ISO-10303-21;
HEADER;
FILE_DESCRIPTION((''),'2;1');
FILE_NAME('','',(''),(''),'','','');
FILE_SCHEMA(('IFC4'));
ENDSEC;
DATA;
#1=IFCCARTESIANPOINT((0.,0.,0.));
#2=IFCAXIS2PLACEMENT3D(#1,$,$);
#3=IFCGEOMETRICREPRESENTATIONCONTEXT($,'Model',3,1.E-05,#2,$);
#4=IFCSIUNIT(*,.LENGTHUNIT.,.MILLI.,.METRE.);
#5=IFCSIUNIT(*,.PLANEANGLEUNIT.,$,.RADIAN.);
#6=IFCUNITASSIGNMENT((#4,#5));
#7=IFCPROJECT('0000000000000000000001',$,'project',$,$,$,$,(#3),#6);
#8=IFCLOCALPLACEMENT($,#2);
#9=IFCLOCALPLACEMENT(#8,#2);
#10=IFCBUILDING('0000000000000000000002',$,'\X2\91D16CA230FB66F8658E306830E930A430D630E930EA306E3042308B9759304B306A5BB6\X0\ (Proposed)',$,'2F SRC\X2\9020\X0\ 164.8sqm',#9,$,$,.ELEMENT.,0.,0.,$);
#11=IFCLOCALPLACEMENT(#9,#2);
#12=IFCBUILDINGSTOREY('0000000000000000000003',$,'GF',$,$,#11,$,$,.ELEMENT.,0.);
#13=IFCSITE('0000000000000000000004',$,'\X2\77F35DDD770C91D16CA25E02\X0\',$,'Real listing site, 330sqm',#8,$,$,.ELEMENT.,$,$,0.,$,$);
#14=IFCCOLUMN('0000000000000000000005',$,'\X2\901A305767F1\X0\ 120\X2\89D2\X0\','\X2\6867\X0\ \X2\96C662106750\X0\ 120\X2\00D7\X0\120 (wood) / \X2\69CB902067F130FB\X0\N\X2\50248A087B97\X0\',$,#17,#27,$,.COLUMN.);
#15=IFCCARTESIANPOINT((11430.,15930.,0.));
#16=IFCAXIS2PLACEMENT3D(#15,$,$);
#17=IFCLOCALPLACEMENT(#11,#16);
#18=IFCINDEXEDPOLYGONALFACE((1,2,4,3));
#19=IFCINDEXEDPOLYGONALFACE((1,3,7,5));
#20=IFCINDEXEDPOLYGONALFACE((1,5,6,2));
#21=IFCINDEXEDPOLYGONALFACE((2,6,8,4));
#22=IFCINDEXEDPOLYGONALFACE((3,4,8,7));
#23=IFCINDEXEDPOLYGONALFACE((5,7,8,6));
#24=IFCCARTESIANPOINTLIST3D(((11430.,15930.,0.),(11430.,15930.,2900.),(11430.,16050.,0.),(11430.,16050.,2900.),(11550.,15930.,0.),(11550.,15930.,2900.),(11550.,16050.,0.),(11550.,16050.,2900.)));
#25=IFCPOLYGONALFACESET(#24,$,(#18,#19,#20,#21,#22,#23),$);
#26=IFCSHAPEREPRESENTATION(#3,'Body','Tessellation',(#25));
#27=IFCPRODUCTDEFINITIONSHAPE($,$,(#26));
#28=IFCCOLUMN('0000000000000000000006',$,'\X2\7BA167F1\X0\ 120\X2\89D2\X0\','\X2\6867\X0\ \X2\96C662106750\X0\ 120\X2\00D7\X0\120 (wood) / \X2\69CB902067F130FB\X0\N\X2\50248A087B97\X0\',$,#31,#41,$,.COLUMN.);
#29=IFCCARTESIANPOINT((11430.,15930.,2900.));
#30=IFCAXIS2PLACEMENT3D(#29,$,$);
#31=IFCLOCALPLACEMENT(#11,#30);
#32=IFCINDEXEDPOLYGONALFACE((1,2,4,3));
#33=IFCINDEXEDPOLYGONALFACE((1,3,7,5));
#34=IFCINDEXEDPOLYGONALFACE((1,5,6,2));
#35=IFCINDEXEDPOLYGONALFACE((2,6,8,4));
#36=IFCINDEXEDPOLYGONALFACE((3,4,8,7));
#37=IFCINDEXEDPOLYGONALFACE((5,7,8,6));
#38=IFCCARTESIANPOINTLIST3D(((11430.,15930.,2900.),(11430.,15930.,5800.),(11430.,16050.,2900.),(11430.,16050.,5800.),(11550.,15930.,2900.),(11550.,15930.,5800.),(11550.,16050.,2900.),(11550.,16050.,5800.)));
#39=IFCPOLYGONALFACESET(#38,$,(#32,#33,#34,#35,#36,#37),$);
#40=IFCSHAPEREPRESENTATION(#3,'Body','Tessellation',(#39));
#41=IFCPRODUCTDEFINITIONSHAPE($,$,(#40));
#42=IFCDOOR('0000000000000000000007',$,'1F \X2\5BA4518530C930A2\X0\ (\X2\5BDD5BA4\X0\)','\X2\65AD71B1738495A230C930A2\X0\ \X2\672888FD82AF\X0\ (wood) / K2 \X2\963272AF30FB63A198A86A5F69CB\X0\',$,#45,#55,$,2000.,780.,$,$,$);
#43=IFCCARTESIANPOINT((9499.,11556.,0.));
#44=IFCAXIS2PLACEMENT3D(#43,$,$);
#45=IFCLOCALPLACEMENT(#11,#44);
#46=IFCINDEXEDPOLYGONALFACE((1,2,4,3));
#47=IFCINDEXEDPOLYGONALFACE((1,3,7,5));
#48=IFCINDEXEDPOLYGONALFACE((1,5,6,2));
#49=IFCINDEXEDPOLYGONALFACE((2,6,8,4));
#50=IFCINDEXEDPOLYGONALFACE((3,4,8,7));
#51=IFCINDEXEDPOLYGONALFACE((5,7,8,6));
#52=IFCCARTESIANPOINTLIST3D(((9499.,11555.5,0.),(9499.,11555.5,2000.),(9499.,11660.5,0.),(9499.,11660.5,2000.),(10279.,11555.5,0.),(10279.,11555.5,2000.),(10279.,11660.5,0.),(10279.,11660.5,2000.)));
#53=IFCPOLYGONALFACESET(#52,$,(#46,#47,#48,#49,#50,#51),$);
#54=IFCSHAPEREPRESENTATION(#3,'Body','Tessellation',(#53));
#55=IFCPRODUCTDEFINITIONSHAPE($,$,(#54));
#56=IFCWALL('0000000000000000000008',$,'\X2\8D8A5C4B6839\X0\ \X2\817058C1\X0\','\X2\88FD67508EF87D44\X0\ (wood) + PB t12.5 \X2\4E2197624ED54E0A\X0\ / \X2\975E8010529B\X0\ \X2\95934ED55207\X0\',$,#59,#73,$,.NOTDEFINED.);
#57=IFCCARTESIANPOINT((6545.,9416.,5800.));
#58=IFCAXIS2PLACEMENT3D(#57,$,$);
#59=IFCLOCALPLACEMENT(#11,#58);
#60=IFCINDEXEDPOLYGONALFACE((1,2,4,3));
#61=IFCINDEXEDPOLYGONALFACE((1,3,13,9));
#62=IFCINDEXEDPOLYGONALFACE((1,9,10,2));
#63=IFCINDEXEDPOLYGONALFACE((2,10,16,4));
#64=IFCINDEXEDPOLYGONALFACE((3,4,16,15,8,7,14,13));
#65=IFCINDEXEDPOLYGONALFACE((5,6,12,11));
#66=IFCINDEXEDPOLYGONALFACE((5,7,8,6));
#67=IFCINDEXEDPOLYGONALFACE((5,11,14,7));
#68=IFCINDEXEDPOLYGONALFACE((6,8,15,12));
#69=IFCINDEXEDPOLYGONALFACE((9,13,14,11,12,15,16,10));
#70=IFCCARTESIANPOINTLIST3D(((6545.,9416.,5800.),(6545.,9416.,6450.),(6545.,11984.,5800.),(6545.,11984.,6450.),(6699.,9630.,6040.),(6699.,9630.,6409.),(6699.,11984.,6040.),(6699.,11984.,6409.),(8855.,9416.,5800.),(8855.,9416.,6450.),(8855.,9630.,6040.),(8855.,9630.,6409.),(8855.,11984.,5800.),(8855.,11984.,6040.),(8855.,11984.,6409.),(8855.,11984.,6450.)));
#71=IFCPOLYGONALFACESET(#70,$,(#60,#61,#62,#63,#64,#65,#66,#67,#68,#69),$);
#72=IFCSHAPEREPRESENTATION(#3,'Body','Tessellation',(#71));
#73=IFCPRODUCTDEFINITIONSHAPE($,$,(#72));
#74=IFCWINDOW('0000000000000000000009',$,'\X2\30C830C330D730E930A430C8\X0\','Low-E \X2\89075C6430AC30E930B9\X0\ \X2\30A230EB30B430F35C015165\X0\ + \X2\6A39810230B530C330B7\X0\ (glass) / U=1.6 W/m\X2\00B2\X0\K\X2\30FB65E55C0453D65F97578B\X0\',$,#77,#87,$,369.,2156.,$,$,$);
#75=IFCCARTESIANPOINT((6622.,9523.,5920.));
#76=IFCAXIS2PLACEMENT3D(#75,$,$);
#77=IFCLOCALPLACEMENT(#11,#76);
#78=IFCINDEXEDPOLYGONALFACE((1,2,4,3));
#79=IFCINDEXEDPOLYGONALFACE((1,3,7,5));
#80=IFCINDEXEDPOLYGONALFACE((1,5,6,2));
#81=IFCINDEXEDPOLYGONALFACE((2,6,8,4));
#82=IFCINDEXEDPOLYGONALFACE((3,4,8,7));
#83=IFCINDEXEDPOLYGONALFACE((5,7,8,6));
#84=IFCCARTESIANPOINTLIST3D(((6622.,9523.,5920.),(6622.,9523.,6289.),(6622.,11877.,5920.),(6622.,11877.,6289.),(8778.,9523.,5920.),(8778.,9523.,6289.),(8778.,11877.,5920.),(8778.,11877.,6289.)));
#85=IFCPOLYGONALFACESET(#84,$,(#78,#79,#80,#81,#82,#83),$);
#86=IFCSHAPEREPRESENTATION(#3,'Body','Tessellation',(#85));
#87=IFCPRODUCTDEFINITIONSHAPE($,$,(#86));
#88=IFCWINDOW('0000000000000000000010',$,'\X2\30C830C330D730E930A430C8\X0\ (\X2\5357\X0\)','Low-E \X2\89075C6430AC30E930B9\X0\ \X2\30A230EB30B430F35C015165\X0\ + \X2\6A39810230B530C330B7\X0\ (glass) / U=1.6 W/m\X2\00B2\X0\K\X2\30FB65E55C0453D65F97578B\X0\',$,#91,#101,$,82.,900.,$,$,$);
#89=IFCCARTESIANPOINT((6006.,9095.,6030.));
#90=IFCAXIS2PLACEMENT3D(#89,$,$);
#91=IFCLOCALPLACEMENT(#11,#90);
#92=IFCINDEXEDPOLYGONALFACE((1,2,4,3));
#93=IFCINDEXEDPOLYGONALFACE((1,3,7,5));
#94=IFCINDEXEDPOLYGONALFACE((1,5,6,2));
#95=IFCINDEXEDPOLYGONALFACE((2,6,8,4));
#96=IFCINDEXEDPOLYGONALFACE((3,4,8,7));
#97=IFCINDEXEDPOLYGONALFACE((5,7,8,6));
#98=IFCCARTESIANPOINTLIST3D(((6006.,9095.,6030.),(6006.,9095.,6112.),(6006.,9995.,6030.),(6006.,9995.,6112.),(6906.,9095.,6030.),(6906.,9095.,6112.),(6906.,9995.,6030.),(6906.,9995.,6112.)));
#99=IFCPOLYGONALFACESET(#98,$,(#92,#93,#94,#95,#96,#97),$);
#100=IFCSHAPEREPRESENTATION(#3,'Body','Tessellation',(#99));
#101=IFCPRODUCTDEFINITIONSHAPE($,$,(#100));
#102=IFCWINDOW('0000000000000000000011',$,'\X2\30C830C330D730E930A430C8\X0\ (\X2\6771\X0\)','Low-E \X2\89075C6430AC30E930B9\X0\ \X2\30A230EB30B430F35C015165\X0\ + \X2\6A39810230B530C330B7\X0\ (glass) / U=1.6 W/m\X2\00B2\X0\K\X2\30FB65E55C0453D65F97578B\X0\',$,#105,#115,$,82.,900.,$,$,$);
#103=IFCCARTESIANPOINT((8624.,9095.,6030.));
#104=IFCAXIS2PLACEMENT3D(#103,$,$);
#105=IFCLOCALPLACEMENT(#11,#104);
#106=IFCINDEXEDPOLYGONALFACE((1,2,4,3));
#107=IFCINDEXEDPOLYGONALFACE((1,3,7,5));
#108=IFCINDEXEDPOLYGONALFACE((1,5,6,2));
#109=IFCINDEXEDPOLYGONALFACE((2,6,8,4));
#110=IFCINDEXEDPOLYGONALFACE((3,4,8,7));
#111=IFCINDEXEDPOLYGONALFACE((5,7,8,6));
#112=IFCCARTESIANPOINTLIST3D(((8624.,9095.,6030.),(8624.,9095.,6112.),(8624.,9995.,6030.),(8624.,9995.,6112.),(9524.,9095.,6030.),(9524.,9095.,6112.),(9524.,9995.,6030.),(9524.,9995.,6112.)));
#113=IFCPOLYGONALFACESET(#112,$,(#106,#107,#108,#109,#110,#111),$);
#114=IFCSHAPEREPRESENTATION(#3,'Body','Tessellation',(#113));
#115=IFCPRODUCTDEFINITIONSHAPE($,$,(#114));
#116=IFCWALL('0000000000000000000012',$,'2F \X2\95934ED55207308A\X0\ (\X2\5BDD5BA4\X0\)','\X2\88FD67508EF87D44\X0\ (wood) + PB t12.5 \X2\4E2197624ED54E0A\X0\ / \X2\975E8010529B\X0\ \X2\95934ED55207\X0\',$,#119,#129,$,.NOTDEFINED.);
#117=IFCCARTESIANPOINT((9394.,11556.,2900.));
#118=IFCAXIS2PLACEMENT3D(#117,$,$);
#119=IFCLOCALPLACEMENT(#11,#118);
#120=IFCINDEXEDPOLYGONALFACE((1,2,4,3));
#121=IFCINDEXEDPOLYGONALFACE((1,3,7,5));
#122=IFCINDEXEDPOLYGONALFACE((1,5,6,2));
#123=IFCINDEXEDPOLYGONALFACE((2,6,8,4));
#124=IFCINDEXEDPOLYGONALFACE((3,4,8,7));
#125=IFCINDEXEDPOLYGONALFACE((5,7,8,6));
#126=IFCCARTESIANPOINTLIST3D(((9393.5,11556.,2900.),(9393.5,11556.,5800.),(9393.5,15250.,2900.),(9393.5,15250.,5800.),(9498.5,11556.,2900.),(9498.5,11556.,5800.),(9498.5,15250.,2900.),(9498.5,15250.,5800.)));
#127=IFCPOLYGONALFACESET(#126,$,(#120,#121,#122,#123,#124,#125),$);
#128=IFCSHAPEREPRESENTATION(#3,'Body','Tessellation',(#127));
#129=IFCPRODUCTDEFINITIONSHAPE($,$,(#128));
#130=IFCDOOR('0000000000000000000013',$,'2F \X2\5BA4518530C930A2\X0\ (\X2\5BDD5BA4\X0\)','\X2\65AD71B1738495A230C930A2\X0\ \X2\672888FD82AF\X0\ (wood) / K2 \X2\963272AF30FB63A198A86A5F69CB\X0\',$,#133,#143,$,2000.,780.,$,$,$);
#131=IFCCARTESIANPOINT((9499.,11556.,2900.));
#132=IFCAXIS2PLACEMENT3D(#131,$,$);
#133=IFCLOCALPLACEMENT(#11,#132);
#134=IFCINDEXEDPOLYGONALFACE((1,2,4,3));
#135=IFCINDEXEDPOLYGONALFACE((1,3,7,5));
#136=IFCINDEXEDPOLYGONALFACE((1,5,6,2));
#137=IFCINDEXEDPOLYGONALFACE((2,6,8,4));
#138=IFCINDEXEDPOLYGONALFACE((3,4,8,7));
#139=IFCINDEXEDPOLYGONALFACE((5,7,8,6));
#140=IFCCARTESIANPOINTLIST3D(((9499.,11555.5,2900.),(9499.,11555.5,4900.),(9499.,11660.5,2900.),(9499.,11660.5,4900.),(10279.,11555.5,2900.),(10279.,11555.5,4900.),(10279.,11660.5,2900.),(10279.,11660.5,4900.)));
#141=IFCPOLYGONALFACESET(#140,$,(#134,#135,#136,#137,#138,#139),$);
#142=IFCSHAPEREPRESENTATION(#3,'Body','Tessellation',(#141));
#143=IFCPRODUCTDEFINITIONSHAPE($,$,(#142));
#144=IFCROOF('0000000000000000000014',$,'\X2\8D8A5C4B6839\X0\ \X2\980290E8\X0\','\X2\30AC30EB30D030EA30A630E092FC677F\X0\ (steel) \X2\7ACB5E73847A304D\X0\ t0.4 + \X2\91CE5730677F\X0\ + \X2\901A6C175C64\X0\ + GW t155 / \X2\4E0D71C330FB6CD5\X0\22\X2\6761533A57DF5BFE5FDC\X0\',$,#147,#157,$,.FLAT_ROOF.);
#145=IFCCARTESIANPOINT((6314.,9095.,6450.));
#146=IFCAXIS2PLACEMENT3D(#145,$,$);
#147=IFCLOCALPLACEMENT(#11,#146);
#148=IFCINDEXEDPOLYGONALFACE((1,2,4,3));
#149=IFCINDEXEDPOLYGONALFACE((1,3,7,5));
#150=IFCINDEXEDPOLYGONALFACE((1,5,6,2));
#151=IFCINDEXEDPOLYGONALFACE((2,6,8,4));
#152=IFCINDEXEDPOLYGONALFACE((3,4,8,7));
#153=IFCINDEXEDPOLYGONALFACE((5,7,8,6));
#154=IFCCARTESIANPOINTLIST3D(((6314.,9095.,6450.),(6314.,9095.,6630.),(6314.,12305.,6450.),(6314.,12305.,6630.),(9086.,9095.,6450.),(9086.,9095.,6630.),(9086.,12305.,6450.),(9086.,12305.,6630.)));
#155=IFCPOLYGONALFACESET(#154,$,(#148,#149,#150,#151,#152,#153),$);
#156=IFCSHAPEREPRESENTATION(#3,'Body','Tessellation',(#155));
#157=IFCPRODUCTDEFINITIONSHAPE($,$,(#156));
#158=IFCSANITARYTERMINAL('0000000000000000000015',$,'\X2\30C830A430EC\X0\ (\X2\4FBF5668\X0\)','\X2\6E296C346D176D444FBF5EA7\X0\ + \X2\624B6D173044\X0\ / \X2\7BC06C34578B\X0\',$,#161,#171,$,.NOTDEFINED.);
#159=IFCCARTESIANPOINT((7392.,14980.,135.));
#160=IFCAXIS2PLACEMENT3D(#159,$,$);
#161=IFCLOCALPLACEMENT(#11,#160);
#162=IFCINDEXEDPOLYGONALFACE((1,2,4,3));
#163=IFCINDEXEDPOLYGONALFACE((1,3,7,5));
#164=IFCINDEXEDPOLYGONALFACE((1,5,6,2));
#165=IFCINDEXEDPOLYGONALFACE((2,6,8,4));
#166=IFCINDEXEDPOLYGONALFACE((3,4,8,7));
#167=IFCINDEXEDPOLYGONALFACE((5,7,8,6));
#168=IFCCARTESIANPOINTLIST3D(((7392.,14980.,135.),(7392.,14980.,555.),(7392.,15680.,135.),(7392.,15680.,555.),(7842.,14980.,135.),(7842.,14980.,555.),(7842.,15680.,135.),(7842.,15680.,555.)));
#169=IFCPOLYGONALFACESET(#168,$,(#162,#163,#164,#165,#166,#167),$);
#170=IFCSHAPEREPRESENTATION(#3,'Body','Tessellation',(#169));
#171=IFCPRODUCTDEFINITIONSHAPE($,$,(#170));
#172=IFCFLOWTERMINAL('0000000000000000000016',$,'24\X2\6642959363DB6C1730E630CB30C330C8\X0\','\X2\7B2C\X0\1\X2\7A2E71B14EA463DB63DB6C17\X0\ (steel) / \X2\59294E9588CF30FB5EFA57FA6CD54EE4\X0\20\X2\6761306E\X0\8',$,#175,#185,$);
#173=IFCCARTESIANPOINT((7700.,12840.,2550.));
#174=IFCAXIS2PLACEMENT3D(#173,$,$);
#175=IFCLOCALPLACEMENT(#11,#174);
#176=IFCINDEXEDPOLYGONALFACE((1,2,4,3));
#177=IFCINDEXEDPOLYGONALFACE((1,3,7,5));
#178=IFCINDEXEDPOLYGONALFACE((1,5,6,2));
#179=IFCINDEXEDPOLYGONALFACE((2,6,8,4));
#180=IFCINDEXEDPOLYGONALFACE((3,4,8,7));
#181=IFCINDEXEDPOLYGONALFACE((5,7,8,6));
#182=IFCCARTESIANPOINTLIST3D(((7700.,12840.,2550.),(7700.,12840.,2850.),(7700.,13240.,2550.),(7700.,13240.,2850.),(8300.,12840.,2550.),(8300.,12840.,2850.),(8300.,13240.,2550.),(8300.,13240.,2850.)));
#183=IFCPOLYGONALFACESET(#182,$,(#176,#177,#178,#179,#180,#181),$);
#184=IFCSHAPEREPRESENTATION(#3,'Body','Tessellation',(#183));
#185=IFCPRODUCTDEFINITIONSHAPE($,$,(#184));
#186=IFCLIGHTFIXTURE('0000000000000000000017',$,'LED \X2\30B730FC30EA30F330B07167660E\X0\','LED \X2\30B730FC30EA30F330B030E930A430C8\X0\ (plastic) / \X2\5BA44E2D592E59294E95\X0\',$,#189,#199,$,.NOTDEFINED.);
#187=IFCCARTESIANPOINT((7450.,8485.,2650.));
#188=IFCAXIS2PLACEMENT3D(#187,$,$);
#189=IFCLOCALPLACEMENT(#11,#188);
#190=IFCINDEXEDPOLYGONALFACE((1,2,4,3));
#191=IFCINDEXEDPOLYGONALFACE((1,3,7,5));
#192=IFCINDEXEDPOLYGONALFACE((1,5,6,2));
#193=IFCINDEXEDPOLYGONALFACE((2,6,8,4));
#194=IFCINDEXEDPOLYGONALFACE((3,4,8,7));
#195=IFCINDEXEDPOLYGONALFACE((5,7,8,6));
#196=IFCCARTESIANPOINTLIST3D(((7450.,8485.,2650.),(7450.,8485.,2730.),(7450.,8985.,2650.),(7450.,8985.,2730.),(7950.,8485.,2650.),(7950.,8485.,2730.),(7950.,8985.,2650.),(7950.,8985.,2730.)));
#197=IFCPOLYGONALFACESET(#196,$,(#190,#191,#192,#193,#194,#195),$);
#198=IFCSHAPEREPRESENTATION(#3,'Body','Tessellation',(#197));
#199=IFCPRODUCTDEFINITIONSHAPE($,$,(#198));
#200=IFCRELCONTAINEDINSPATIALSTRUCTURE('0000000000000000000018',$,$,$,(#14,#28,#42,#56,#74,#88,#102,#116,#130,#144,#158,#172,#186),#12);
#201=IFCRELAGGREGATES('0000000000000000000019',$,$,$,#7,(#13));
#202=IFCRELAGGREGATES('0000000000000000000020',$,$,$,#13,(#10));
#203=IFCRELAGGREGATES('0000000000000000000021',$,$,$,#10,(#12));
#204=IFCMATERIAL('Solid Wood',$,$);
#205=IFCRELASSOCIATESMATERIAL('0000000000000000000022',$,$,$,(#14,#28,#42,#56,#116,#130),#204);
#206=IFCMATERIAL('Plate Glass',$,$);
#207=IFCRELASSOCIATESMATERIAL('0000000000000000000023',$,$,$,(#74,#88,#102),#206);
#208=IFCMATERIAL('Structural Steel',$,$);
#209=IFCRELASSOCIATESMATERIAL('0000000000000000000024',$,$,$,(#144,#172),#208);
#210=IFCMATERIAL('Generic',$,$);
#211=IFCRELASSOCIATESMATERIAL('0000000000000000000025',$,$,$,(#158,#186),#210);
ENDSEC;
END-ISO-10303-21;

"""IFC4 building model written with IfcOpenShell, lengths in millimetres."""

from ifc_helpers import new_model, si_unit, frame, frame_2d, origin, place, context, project, spatial, rectangle, extrude, material, element, fill, save


model = new_model("IFC4")

# Units and contexts
model_context = context("Model", 3, precision=1e-05, world=origin())
ifc_project = project(units=[si_unit("LENGTHUNIT", "METRE", prefix="MILLI"), si_unit("PLANEANGLEUNIT", "RADIAN")], contexts=[model_context])

# Site, building, storey
site_placement = place(None, origin())
site = spatial("IfcSite", under=ifc_project, at=site_placement, Name="石川県金沢市", ObjectType="Real listing site, 330sqm", CompositionType="ELEMENT", RefElevation=0.0)
building_placement = place(site_placement, origin())
building = spatial("IfcBuilding", under=site, at=building_placement, Name="金沢・書斎とライブラリのある静かな家 (Proposed)", ObjectType="2F SRC造 164.8sqm", CompositionType="ELEMENT", ElevationOfRefHeight=0.0, ElevationOfTerrain=0.0)
storey_placement = place(building_placement, origin())
storey = spatial("IfcBuildingStorey", under=building, at=storey_placement, Name="GF", CompositionType="ELEMENT", Elevation=0.0)

# Columns
ifc_material_1 = material(Name="Solid Wood")
column_1_placement = place(storey_placement, frame((11430.0, 15930.0, 0.0)))
element("IfcColumn", 1, at=column_1_placement, inside=storey, material=ifc_material_1, Name="通し柱 120角", Description="桧 集成材 120×120 (wood) / 構造柱・N値計算", PredefinedType="COLUMN", context=model_context, shape_type="SweptSolid", body=[
    extrude(rectangle(XDim=120.0, YDim=120.0, at=frame_2d((60.0, 60.0))), frame((11430.0, 15930.0, 0.0)), (0.0, 0.0, 1.0), 2900.0),
])
column_2_placement = place(storey_placement, frame((11430.0, 15930.0, 2900.0)))
element("IfcColumn", 2, at=column_2_placement, inside=storey, material=ifc_material_1, Name="管柱 120角", Description="桧 集成材 120×120 (wood) / 構造柱・N値計算", PredefinedType="COLUMN", context=model_context, shape_type="SweptSolid", body=[
    extrude(rectangle(XDim=120.0, YDim=120.0, at=frame_2d((60.0, 60.0))), frame((11430.0, 15930.0, 2900.0)), (0.0, 0.0, 1.0), 2900.0),
])

# Door
door_1_placement = place(storey_placement, frame((9499.0, 11556.0, 0.0)))
element("IfcDoor", 3, at=door_1_placement, inside=storey, material=ifc_material_1, Name="1F 室内ドア (寝室)", Description="断熱玄関ドア 木製芯 (wood) / K2 防犯・採風機構", OverallHeight=2000.0, OverallWidth=780.0, context=model_context, shape_type="SweptSolid", body=[
    extrude(rectangle(XDim=780.0, YDim=105.0, at=frame_2d((390.0, 52.0))), frame((9499.0, 11556.0, 0.0)), (0.0, 0.0, 1.0), 2000.0),
])

# Wall, openings, windows
wall_1_placement = place(storey_placement, frame((6545.0, 9416.0, 5800.0)))
wall_1 = element("IfcWall", 4, at=wall_1_placement, inside=storey, material=ifc_material_1, Name="越屋根 腰壁", Description="製材軸組 (wood) + PB t12.5 両面仕上 / 非耐力 間仕切", PredefinedType="NOTDEFINED", context=model_context, shape_type="SweptSolid", body=[
    extrude(rectangle(XDim=2310.0, YDim=2568.0, at=frame_2d((1155.0, 1284.0))), frame((6545.0, 9416.0, 5800.0)), (0.0, 0.0, 1.0), 650.0),
])
opening_1_placement = place(storey_placement, frame((6622.0, 9523.0, 5920.0)))
opening_1 = element("IfcOpeningElement", 5, at=opening_1_placement, cuts=wall_1, PredefinedType="NOTDEFINED", context=model_context, shape_type="SweptSolid", body=[
    extrude(rectangle(XDim=2156.0, YDim=2354.0, at=frame_2d((1078.0, 1177.0))), frame((6622.0, 9523.0, 5920.0)), (0.0, 0.0, 1.0), 369.0),
])
opening_2_placement = place(storey_placement, frame((6006.0, 9095.0, 6030.0)))
opening_2 = element("IfcOpeningElement", 6, at=opening_2_placement, cuts=wall_1, PredefinedType="NOTDEFINED", context=model_context, shape_type="SweptSolid", body=[
    extrude(rectangle(XDim=900.0, YDim=900.0, at=frame_2d((450.0, 450.0))), frame((6006.0, 9095.0, 6030.0)), (0.0, 0.0, 1.0), 82.0),
])
opening_3_placement = place(storey_placement, frame((8624.0, 9095.0, 6030.0)))
opening_3 = element("IfcOpeningElement", 7, at=opening_3_placement, cuts=wall_1, PredefinedType="NOTDEFINED", context=model_context, shape_type="SweptSolid", body=[
    extrude(rectangle(XDim=900.0, YDim=900.0, at=frame_2d((450.0, 450.0))), frame((8624.0, 9095.0, 6030.0)), (0.0, 0.0, 1.0), 82.0),
])
ifc_material_2 = material(Name="Plate Glass")
window_1_placement = place(storey_placement, frame((6622.0, 9523.0, 5920.0)))
window_1 = element("IfcWindow", 8, at=window_1_placement, inside=storey, material=ifc_material_2, Name="トップライト", Description="Low-E 複層ガラス アルゴン封入 + 樹脂サッシ (glass) / U=1.6 W/m²K・日射取得型", OverallHeight=369.0, OverallWidth=2156.0, context=model_context, shape_type="SweptSolid", body=[
    extrude(rectangle(XDim=2156.0, YDim=2354.0, at=frame_2d((1078.0, 1177.0))), frame((6622.0, 9523.0, 5920.0)), (0.0, 0.0, 1.0), 369.0),
])
fill(opening_1, window_1)
window_2_placement = place(storey_placement, frame((6006.0, 9095.0, 6030.0)))
window_2 = element("IfcWindow", 9, at=window_2_placement, inside=storey, material=ifc_material_2, Name="トップライト (南)", Description="Low-E 複層ガラス アルゴン封入 + 樹脂サッシ (glass) / U=1.6 W/m²K・日射取得型", OverallHeight=82.0, OverallWidth=900.0, context=model_context, shape_type="SweptSolid", body=[
    extrude(rectangle(XDim=900.0, YDim=900.0, at=frame_2d((450.0, 450.0))), frame((6006.0, 9095.0, 6030.0)), (0.0, 0.0, 1.0), 82.0),
])
fill(opening_2, window_2)
window_3_placement = place(storey_placement, frame((8624.0, 9095.0, 6030.0)))
window_3 = element("IfcWindow", 10, at=window_3_placement, inside=storey, material=ifc_material_2, Name="トップライト (東)", Description="Low-E 複層ガラス アルゴン封入 + 樹脂サッシ (glass) / U=1.6 W/m²K・日射取得型", OverallHeight=82.0, OverallWidth=900.0, context=model_context, shape_type="SweptSolid", body=[
    extrude(rectangle(XDim=900.0, YDim=900.0, at=frame_2d((450.0, 450.0))), frame((8624.0, 9095.0, 6030.0)), (0.0, 0.0, 1.0), 82.0),
])
fill(opening_3, window_3)

# Wall
wall_2_placement = place(storey_placement, frame((9394.0, 11556.0, 2900.0)))
element("IfcWall", 11, at=wall_2_placement, inside=storey, material=ifc_material_1, Name="2F 間仕切り (寝室)", Description="製材軸組 (wood) + PB t12.5 両面仕上 / 非耐力 間仕切", PredefinedType="NOTDEFINED", context=model_context, shape_type="SweptSolid", body=[
    extrude(rectangle(XDim=105.0, YDim=3694.0, at=frame_2d((52.0, 1847.0))), frame((9394.0, 11556.0, 2900.0)), (0.0, 0.0, 1.0), 2900.0),
])

# Door
door_2_placement = place(storey_placement, frame((9499.0, 11556.0, 2900.0)))
element("IfcDoor", 12, at=door_2_placement, inside=storey, material=ifc_material_1, Name="2F 室内ドア (寝室)", Description="断熱玄関ドア 木製芯 (wood) / K2 防犯・採風機構", OverallHeight=2000.0, OverallWidth=780.0, context=model_context, shape_type="SweptSolid", body=[
    extrude(rectangle(XDim=780.0, YDim=105.0, at=frame_2d((390.0, 52.0))), frame((9499.0, 11556.0, 2900.0)), (0.0, 0.0, 1.0), 2000.0),
])

# Roof
ifc_material_3 = material(Name="Structural Steel")
roof_placement = place(storey_placement, frame((6314.0, 9095.0, 6450.0)))
element("IfcRoof", 13, at=roof_placement, inside=storey, material=ifc_material_3, Name="越屋根 頂部", Description="ガルバリウム鋼板 (steel) 立平葺き t0.4 + 野地板 + 通気層 + GW t155 / 不燃・法22条区域対応", PredefinedType="FLAT_ROOF", context=model_context, shape_type="SweptSolid", body=[
    extrude(rectangle(XDim=2772.0, YDim=3210.0, at=frame_2d((1386.0, 1605.0))), frame((6314.0, 9095.0, 6450.0)), (0.0, 0.0, 1.0), 180.0),
])

# Sanitary terminal
ifc_material_4 = material(Name="Generic")
sanitary_terminal_placement = place(storey_placement, frame((7392.0, 14980.0, 135.0)))
element("IfcSanitaryTerminal", 14, at=sanitary_terminal_placement, inside=storey, material=ifc_material_4, Name="トイレ (便器)", Description="温水洗浄便座 + 手洗い / 節水型", PredefinedType="NOTDEFINED", context=model_context, shape_type="SweptSolid", body=[
    extrude(rectangle(XDim=450.0, YDim=700.0, at=frame_2d((225.0, 350.0))), frame((7392.0, 14980.0, 135.0)), (0.0, 0.0, 1.0), 420.0),
])

# Flow terminal
flow_terminal_placement = place(storey_placement, frame((7700.0, 12840.0, 2550.0)))
element("IfcFlowTerminal", 15, at=flow_terminal_placement, inside=storey, material=ifc_material_3, Name="24時間換気ユニット", Description="第1種熱交換換気 (steel) / 天井裏・建基法令20条の8", context=model_context, shape_type="SweptSolid", body=[
    extrude(rectangle(XDim=600.0, YDim=400.0, at=frame_2d((300.0, 200.0))), frame((7700.0, 12840.0, 2550.0)), (0.0, 0.0, 1.0), 300.0),
])

# Light fixture
light_fixture_1_placement = place(storey_placement, frame((7450.0, 8485.0, 2650.0)))
element("IfcLightFixture", 16, at=light_fixture_1_placement, inside=storey, material=ifc_material_4, Name="LED シーリング照明", Description="LED シーリングライト (plastic) / 室中央天井", PredefinedType="NOTDEFINED", context=model_context, shape_type="SweptSolid", body=[
    extrude(rectangle(XDim=500.0, YDim=500.0, at=frame_2d((250.0, 250.0))), frame((7450.0, 8485.0, 2650.0)), (0.0, 0.0, 1.0), 80.0),
])

save(model, "model.ifc")
